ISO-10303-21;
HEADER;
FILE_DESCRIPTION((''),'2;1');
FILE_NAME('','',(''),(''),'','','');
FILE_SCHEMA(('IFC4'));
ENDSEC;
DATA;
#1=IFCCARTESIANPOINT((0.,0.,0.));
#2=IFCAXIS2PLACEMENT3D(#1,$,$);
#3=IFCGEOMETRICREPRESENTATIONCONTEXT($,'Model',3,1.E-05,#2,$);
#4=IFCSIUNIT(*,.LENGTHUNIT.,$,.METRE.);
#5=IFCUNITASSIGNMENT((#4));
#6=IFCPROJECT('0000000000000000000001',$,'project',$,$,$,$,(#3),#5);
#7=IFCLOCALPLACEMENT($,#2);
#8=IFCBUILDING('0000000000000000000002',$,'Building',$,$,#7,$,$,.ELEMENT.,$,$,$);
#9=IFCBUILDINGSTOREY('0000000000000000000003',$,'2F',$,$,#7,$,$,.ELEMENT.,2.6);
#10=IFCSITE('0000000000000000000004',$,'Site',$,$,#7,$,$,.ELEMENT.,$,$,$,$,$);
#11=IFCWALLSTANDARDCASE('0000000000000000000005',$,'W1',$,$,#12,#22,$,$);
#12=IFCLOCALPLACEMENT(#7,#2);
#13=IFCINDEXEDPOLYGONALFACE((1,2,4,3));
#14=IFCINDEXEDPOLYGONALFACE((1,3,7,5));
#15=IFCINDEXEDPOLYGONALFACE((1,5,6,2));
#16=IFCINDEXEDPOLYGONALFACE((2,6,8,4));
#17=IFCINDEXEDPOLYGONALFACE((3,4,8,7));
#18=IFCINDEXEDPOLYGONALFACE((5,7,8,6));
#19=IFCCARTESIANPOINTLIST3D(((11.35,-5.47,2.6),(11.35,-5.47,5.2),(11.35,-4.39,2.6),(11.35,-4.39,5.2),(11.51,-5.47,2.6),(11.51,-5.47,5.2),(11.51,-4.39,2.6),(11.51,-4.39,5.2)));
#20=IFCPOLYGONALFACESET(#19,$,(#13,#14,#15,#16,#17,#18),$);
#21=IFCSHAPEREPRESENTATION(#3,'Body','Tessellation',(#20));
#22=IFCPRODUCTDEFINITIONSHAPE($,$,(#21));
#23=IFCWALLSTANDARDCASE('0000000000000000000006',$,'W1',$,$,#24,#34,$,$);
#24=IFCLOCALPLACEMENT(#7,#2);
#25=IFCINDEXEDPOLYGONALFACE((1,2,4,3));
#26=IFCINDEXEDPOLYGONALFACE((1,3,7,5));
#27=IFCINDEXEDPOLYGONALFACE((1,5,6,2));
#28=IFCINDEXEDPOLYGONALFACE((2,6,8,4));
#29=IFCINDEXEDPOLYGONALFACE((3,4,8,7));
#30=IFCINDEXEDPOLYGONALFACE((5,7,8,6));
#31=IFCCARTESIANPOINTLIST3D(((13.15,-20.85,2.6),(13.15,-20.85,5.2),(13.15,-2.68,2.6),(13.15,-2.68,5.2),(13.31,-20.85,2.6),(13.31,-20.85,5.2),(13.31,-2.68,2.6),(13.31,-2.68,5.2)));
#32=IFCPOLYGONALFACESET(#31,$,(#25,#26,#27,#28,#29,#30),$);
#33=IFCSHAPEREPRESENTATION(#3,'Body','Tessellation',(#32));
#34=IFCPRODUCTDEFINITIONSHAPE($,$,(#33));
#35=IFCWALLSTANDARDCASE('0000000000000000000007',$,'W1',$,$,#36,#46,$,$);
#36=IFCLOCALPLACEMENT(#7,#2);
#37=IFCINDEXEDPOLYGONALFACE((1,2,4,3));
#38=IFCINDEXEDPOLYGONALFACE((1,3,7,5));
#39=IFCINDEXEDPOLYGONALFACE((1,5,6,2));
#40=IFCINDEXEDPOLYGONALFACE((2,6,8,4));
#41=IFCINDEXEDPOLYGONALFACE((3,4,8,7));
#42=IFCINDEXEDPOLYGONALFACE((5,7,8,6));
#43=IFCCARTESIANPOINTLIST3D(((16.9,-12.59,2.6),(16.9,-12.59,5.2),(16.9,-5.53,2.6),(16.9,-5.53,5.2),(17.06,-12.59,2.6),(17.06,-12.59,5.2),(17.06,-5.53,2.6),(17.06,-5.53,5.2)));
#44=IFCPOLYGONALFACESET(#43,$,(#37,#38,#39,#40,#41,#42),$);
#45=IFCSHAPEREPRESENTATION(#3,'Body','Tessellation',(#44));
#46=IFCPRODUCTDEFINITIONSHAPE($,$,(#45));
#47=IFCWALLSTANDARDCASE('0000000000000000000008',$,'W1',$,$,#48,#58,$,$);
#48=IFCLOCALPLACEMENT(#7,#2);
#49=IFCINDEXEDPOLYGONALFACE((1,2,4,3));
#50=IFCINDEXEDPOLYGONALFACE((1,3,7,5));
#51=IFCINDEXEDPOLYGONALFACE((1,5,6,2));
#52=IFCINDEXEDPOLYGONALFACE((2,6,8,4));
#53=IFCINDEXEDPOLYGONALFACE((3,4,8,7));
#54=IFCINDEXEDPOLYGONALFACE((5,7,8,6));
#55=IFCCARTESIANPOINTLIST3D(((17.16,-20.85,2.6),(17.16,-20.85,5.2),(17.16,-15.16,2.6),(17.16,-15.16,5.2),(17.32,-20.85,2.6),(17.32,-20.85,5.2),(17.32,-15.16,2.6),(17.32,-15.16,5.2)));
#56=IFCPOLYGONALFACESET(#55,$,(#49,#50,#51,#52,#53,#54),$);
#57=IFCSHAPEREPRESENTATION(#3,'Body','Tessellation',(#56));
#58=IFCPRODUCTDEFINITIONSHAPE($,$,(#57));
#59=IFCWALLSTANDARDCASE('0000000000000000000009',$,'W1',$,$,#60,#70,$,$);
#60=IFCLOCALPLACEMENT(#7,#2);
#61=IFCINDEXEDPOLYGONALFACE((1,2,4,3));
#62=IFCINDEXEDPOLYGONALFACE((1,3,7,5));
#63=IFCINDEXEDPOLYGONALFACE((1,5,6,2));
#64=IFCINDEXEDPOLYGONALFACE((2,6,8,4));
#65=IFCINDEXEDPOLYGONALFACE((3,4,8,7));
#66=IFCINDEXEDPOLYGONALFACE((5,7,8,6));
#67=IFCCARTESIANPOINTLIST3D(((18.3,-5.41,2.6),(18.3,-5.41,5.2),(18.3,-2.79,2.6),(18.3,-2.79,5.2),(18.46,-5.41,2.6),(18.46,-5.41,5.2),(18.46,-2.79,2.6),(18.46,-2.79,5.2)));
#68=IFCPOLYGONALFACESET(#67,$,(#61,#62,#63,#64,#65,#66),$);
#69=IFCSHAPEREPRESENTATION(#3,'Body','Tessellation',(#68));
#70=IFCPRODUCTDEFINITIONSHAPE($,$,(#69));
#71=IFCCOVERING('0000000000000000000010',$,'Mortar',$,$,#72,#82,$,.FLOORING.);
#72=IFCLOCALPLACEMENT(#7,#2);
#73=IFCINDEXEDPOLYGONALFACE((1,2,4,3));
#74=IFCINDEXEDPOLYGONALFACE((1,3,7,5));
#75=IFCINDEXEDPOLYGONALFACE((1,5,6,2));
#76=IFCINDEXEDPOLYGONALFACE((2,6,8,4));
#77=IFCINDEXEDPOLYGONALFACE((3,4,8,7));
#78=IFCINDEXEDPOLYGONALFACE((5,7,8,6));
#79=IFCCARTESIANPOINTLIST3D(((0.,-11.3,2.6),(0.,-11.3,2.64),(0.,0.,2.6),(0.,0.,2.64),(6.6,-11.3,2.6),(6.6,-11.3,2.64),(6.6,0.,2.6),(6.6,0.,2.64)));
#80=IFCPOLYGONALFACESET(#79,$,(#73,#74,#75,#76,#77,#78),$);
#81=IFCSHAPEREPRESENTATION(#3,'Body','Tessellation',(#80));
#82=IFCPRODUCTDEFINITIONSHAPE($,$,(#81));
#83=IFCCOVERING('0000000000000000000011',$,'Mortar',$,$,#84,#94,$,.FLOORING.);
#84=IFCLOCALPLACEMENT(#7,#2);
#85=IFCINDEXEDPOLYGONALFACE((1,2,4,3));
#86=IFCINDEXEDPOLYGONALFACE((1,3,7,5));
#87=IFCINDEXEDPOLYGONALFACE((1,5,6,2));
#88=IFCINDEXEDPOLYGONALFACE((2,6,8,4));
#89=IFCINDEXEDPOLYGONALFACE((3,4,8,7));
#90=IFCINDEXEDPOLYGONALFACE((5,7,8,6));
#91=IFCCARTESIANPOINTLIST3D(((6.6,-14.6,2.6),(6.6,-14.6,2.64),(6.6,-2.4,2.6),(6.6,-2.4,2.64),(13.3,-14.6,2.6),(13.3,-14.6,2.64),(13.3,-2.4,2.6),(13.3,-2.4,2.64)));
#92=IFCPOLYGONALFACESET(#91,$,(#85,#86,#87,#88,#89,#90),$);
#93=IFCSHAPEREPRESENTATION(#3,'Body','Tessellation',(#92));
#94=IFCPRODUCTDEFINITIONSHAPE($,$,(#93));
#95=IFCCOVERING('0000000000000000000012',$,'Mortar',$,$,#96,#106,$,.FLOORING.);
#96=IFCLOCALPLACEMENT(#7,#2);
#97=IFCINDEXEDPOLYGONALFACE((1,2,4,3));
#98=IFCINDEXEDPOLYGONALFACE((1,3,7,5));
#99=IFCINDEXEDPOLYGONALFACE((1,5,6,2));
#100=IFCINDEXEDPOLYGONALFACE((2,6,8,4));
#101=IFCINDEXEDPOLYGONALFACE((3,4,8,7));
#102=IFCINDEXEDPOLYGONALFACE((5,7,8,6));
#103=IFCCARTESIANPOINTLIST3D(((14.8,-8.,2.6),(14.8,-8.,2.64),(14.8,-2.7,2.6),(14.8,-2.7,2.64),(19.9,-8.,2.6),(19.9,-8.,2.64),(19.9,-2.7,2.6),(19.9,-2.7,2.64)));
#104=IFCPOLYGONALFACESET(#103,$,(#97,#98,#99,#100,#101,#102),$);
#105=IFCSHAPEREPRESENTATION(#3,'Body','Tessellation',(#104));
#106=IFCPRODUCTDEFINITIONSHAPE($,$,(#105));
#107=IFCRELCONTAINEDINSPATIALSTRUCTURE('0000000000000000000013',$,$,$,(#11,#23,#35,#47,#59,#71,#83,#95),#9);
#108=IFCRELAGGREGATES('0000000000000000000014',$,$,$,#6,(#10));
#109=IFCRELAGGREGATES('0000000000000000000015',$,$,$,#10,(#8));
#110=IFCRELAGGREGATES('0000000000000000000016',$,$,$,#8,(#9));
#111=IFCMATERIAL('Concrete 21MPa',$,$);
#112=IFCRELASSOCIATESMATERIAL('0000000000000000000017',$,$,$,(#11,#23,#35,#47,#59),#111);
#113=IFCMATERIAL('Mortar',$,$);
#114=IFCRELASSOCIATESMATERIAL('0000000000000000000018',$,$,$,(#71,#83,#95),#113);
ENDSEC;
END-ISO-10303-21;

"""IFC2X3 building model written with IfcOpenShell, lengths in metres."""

from ifc_helpers import new_model, si_unit, frame, origin, origin_2d, place, context, project, spatial, rectangle, extrude, material, element, save


model = new_model("IFC2X3")

# Units and contexts
model_context = context("Model", 3, precision=1e-05, world=origin())
ifc_project = project(units=[si_unit("LENGTHUNIT", "METRE")], contexts=[model_context])

# Site, building, storey
placement = place(None, origin())
site = spatial("IfcSite", under=ifc_project, at=placement, Name="Site", CompositionType="ELEMENT")
building = spatial("IfcBuilding", under=site, at=placement, Name="Building", CompositionType="ELEMENT")
storey = spatial("IfcBuildingStorey", under=building, at=placement, Name="2F", CompositionType="ELEMENT", Elevation=2.6)

# Shared definitions
ifc_material_1 = material(Name="Concrete 21MPa")

# Walls
wall_1_placement = place(None, frame((11.43, -4.93, 2.6)))
element("IfcWallStandardCase", 1, at=wall_1_placement, inside=storey, material=ifc_material_1, Name="W1", context=model_context, shape_type="SweptSolid", body=[
    extrude(rectangle(XDim=0.16, YDim=1.08, at=origin_2d()), origin(), (0.0, 0.0, 1.0), 2.6),
])
wall_2_placement = place(None, frame((13.23, -11.765, 2.6)))
element("IfcWallStandardCase", 2, at=wall_2_placement, inside=storey, material=ifc_material_1, Name="W1", context=model_context, shape_type="SweptSolid", body=[
    extrude(rectangle(XDim=0.16, YDim=18.17, at=origin_2d()), origin(), (0.0, 0.0, 1.0), 2.6),
])
wall_3_placement = place(None, frame((16.98, -9.06, 2.6)))
element("IfcWallStandardCase", 3, at=wall_3_placement, inside=storey, material=ifc_material_1, Name="W1", context=model_context, shape_type="SweptSolid", body=[
    extrude(rectangle(XDim=0.16, YDim=7.06, at=origin_2d()), origin(), (0.0, 0.0, 1.0), 2.6),
])
wall_4_placement = place(None, frame((17.24, -18.005, 2.6)))
element("IfcWallStandardCase", 4, at=wall_4_placement, inside=storey, material=ifc_material_1, Name="W1", context=model_context, shape_type="SweptSolid", body=[
    extrude(rectangle(XDim=0.16, YDim=5.69, at=origin_2d()), origin(), (0.0, 0.0, 1.0), 2.6),
])
wall_5_placement = place(None, frame((18.38, -4.1, 2.6)))
element("IfcWallStandardCase", 5, at=wall_5_placement, inside=storey, material=ifc_material_1, Name="W1", context=model_context, shape_type="SweptSolid", body=[
    extrude(rectangle(XDim=0.16, YDim=2.62, at=origin_2d()), origin(), (0.0, 0.0, 1.0), 2.6),
])

# Coverings
ifc_material_2 = material(Name="Mortar")
covering_1_placement = place(None, frame((3.3, -5.65, 2.6)))
element("IfcCovering", 6, at=covering_1_placement, inside=storey, material=ifc_material_2, Name="Mortar", PredefinedType="FLOORING", context=model_context, shape_type="SweptSolid", body=[
    extrude(rectangle(XDim=6.6, YDim=11.3, at=origin_2d()), origin(), (0.0, 0.0, 1.0), 0.04),
])
covering_2_placement = place(None, frame((9.95, -8.5, 2.6)))
element("IfcCovering", 7, at=covering_2_placement, inside=storey, material=ifc_material_2, Name="Mortar", PredefinedType="FLOORING", context=model_context, shape_type="SweptSolid", body=[
    extrude(rectangle(XDim=6.7, YDim=12.2, at=origin_2d()), origin(), (0.0, 0.0, 1.0), 0.04),
])
covering_3_placement = place(None, frame((17.35, -5.35, 2.6)))
element("IfcCovering", 8, at=covering_3_placement, inside=storey, material=ifc_material_2, Name="Mortar", PredefinedType="FLOORING", context=model_context, shape_type="SweptSolid", body=[
    extrude(rectangle(XDim=5.1, YDim=5.3, at=origin_2d()), origin(), (0.0, 0.0, 1.0), 0.04),
])

save(model, "model.ifc")
